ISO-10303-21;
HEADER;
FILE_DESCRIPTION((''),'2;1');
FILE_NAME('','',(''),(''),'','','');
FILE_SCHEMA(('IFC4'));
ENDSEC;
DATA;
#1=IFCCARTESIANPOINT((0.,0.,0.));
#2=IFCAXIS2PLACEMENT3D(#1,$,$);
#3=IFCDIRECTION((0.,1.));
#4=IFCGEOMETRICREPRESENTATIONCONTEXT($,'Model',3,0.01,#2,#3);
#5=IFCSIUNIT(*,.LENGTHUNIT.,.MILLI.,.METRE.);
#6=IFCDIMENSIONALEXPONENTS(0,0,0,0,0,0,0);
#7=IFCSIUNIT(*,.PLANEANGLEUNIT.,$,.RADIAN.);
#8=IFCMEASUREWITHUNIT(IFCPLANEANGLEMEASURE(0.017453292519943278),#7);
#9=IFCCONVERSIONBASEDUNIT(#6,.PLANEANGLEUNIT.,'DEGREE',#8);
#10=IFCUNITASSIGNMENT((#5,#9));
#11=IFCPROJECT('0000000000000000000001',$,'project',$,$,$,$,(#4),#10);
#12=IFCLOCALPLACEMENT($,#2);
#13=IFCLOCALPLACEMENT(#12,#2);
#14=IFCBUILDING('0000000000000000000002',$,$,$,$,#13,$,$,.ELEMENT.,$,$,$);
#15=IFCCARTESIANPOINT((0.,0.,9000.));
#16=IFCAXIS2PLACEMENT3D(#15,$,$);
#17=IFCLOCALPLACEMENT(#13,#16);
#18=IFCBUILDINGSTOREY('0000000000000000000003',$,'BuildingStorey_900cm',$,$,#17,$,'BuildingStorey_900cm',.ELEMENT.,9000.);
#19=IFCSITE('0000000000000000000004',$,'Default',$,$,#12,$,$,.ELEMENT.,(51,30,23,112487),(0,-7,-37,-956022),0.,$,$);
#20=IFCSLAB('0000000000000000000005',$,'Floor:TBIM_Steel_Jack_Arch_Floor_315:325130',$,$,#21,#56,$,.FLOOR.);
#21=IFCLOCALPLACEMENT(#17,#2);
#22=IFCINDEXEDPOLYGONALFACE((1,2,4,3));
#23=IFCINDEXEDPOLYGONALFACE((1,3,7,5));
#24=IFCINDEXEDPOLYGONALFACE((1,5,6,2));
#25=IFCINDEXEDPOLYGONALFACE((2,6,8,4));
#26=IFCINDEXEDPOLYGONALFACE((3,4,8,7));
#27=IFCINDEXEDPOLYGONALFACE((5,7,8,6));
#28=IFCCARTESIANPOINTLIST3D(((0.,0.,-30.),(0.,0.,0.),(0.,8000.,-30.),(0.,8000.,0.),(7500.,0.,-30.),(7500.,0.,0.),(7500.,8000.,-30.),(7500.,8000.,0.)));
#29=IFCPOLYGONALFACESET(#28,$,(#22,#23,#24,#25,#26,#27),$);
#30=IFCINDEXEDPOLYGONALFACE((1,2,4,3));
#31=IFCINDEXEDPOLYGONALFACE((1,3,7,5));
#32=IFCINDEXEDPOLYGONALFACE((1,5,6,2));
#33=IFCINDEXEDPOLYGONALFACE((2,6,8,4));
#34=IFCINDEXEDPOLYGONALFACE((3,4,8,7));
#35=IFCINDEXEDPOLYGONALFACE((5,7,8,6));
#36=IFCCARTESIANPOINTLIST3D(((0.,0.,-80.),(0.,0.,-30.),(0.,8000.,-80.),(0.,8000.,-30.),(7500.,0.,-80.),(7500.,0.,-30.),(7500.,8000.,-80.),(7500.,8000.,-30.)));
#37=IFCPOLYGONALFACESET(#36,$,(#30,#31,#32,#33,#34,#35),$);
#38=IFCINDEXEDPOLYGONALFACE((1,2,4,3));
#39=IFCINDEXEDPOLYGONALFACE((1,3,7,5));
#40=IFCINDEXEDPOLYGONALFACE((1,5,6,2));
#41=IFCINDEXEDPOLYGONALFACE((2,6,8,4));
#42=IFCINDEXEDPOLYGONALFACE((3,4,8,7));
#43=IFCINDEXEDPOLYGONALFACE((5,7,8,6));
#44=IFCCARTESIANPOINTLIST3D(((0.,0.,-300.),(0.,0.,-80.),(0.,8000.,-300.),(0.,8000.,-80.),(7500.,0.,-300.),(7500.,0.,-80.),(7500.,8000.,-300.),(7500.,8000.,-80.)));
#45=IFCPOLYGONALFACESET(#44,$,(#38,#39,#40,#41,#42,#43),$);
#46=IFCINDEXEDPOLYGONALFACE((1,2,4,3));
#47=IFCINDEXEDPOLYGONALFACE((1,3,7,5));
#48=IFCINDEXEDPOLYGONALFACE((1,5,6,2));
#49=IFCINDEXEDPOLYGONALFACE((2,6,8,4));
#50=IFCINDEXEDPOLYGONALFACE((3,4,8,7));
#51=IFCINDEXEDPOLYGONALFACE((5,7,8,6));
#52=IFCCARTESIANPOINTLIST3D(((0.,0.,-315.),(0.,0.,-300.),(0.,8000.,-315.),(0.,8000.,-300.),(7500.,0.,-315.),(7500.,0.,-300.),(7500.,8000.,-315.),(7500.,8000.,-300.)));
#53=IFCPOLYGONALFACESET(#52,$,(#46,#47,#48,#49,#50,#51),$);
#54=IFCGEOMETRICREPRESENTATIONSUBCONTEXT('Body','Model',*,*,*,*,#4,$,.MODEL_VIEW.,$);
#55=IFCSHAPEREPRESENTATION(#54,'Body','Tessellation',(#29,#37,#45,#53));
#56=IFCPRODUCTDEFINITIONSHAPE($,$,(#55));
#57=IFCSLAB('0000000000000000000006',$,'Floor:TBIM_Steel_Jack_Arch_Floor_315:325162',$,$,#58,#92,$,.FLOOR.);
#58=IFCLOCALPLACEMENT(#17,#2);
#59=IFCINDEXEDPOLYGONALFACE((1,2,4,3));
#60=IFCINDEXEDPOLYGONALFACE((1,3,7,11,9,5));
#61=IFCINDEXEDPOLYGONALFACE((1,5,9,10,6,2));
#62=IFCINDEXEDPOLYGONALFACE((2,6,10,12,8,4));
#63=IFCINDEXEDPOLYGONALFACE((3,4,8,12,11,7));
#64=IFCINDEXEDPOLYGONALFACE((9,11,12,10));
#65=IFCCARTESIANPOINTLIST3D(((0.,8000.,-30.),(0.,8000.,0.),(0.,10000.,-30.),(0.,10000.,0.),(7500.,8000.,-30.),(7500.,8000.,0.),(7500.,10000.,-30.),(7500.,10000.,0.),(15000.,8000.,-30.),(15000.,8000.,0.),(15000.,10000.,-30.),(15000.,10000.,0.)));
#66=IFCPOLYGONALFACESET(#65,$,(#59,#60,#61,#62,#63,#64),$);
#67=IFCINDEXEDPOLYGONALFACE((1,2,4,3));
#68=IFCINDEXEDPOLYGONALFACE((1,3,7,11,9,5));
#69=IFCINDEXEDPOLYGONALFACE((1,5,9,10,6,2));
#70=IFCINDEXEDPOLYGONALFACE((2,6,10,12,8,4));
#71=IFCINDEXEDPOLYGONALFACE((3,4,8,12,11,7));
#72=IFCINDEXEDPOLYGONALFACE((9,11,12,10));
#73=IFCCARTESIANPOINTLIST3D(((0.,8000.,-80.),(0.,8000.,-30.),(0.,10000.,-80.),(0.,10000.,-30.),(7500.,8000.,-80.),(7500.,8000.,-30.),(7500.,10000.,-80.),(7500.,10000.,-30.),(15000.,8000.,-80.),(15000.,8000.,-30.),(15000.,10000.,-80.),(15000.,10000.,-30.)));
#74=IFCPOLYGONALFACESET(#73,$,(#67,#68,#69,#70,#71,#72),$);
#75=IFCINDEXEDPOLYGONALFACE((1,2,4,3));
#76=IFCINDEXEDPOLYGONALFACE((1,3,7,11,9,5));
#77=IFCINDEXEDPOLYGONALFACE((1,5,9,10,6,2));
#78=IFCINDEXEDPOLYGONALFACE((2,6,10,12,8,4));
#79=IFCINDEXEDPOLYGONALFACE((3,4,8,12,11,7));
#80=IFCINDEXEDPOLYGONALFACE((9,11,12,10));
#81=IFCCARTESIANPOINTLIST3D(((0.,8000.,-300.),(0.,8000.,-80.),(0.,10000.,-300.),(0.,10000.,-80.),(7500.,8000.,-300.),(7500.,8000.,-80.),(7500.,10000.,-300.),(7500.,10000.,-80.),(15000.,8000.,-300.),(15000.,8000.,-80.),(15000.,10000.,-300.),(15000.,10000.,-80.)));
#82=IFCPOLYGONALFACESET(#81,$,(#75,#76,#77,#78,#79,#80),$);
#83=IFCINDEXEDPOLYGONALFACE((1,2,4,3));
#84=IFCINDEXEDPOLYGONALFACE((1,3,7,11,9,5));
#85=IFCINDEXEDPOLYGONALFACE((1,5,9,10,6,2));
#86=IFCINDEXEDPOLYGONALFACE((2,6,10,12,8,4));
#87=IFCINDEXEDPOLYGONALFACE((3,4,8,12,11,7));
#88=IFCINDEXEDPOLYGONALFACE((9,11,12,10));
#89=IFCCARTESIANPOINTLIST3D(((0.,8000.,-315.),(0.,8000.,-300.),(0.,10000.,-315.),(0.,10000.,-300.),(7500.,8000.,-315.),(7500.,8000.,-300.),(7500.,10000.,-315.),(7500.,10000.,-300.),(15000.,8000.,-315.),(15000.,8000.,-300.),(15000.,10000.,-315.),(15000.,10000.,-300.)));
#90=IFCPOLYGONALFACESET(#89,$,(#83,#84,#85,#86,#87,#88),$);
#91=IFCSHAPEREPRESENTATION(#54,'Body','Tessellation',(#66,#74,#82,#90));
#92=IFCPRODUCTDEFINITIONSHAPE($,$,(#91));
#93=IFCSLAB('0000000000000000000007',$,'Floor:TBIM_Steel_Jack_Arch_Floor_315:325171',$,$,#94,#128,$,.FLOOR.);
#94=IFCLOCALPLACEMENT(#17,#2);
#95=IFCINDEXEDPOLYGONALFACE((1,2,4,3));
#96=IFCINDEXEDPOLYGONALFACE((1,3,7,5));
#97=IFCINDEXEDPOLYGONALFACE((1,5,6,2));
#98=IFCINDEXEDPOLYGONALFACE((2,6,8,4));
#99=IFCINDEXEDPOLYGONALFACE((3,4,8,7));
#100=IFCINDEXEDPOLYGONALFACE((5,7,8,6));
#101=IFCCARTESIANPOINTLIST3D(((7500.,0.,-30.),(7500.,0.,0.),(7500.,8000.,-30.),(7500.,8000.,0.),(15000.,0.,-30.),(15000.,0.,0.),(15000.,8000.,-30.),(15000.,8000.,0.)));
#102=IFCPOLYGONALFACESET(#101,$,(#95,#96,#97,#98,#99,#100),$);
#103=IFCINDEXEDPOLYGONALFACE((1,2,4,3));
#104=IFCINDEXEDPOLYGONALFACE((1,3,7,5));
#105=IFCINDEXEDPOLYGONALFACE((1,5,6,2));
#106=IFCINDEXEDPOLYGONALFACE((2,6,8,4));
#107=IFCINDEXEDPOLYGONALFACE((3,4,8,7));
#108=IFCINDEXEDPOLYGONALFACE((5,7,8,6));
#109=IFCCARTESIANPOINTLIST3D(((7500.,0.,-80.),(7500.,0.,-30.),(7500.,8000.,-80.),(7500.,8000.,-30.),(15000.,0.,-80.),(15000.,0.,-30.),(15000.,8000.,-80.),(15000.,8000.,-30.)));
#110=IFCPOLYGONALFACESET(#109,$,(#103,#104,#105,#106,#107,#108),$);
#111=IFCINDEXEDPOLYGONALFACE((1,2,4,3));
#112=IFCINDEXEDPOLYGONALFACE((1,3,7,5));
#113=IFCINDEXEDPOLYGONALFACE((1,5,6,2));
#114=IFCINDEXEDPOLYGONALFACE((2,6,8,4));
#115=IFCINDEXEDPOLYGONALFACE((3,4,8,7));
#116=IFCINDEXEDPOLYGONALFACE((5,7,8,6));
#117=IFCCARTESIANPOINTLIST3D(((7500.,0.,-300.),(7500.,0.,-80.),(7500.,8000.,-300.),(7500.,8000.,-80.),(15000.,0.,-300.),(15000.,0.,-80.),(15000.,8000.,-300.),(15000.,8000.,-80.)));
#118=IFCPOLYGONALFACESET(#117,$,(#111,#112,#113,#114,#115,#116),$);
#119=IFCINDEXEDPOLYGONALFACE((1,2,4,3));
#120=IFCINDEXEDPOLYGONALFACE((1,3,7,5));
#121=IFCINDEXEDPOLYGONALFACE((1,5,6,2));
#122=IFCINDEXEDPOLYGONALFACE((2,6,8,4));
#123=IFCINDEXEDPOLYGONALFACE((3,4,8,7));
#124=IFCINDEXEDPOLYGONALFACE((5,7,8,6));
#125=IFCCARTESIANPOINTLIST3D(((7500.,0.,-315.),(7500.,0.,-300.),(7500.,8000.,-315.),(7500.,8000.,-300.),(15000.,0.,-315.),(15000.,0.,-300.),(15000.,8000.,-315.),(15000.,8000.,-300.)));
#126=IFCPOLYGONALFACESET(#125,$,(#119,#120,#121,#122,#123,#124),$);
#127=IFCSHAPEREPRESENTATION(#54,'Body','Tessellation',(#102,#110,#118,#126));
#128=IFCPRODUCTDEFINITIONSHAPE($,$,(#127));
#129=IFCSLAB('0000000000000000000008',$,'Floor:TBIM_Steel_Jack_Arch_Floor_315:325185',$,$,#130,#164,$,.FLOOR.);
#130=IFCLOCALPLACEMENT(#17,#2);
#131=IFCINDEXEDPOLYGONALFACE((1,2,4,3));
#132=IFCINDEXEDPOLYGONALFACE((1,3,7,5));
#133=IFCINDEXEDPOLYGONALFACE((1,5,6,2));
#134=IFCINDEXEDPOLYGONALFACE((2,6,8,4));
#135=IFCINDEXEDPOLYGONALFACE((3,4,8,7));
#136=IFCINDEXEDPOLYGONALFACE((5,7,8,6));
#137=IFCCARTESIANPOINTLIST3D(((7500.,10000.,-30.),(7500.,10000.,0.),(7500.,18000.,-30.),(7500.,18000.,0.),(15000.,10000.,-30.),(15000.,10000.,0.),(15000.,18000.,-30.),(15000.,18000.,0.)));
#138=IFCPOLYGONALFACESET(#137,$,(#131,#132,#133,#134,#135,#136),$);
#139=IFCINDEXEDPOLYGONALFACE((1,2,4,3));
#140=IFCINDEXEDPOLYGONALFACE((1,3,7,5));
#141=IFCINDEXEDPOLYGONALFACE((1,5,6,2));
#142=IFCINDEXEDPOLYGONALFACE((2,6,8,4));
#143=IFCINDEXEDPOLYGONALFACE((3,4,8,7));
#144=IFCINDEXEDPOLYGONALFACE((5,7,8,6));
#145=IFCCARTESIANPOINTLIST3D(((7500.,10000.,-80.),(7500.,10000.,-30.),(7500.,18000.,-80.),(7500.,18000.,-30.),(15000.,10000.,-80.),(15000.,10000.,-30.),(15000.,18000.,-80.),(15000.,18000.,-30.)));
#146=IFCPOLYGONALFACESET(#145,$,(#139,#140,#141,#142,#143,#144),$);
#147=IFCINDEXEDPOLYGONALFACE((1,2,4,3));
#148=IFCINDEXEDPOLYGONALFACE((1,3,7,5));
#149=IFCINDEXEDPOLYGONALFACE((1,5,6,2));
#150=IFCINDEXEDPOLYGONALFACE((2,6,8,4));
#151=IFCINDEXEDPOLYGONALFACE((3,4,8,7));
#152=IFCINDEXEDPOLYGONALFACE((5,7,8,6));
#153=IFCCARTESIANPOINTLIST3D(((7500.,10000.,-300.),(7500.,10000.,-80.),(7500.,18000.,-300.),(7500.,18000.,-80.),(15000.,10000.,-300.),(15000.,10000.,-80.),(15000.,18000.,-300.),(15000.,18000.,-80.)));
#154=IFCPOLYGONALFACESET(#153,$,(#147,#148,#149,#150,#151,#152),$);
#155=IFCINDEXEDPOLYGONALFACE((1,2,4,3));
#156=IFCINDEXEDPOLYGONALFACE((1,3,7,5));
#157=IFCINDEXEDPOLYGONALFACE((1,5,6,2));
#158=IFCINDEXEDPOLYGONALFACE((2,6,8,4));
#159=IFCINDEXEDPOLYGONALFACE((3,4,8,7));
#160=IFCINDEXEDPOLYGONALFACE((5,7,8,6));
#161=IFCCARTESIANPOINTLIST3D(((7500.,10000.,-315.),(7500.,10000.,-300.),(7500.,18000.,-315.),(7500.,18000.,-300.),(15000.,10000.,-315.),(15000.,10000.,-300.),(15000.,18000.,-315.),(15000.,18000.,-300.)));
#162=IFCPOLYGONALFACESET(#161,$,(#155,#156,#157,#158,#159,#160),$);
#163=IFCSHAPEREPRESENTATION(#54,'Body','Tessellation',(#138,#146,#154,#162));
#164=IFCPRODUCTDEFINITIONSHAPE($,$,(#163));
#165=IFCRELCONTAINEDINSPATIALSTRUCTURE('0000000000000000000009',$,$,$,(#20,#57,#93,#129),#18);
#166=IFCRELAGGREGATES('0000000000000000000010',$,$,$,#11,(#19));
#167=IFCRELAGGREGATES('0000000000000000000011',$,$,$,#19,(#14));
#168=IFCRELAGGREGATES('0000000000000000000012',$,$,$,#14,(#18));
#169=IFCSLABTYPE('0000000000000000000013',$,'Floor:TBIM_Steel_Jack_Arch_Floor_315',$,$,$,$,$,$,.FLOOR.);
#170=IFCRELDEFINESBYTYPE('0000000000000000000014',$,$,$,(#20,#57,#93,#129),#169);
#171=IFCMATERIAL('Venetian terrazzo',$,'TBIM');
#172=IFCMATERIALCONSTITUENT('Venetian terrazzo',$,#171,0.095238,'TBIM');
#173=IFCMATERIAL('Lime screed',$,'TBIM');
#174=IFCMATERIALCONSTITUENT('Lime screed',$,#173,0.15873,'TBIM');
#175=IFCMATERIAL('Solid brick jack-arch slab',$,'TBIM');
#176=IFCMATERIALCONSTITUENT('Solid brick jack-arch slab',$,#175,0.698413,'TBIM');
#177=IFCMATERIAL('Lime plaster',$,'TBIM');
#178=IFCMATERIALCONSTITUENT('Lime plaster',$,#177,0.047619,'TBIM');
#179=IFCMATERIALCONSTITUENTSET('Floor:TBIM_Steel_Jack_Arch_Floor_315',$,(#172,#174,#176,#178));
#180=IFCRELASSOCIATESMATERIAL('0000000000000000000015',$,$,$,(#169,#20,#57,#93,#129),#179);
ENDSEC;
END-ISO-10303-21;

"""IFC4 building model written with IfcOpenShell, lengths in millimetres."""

from ifc_helpers import new_model, entity, si_unit, converted_unit, direction, frame, origin, place, context, subcontext, project, spatial, indexed_curve, outline, extrude, material, constituent, constituent_set, type_object, element, save


model = new_model("IFC4")

# Units and contexts
model_context = context("Model", 3, precision=0.01, world=origin(), true_north=direction((0.0, 1.0)))
body_context = subcontext(model_context, "Body", "Model", "MODEL_VIEW")
ifc_project = project(units=[si_unit("LENGTHUNIT", "METRE", prefix="MILLI"), converted_unit("PLANEANGLEUNIT", "DEGREE", entity("IfcPlaneAngleMeasure", 0.017453292519943278), si_unit("PLANEANGLEUNIT", "RADIAN"), dimensions=[0, 0, 0, 0, 0, 0, 0])], contexts=[model_context])

# Site, building, storey
site_placement = place(None, origin())
site = spatial("IfcSite", under=ifc_project, at=site_placement, Name="Default", CompositionType="ELEMENT", RefLatitude=(51, 30, 23, 112487), RefLongitude=(0, -7, -37, -956022), RefElevation=0.0)
building_placement = place(site_placement, origin())
building = spatial("IfcBuilding", under=site, at=building_placement, CompositionType="ELEMENT")
storey_placement = place(building_placement, frame((0.0, 0.0, 9000.0)))
storey = spatial("IfcBuildingStorey", under=building, at=storey_placement, Name="BuildingStorey_900cm", LongName="BuildingStorey_900cm", CompositionType="ELEMENT", Elevation=9000.0)

# Slabs
ifc_material_1 = material(Name="Venetian terrazzo", Category="TBIM")
ifc_constituent_1 = constituent(ifc_material_1, Name="Venetian terrazzo", Category="TBIM", fraction=0.095238)
ifc_material_2 = material(Name="Lime screed", Category="TBIM")
ifc_constituent_2 = constituent(ifc_material_2, Name="Lime screed", Category="TBIM", fraction=0.15873)
ifc_material_3 = material(Name="Solid brick jack-arch slab", Category="TBIM")
ifc_constituent_3 = constituent(ifc_material_3, Name="Solid brick jack-arch slab", Category="TBIM", fraction=0.698413)
ifc_material_4 = material(Name="Lime plaster", Category="TBIM")
ifc_constituent_4 = constituent(ifc_material_4, Name="Lime plaster", Category="TBIM", fraction=0.047619)
ifc_constituent_set_1 = constituent_set(constituents=[ifc_constituent_1, ifc_constituent_2, ifc_constituent_3, ifc_constituent_4], Name="Floor:TBIM_Steel_Jack_Arch_Floor_315")
slab_type = type_object("IfcSlabType", Name="Floor:TBIM_Steel_Jack_Arch_Floor_315", PredefinedType="FLOOR", material=ifc_constituent_set_1)
slab_1_placement = place(storey_placement, origin())
element("IfcSlab", 1, at=slab_1_placement, inside=storey, type_object=slab_type, material=ifc_constituent_set_1, Name="Floor:TBIM_Steel_Jack_Arch_Floor_315:325130", PredefinedType="FLOOR", context=body_context, shape_type="SweptSolid", body=[
    extrude(outline(indexed_curve([(-3750.0, -4000.0), (3750.0, -4000.0), (3750.0, 4000.0), (-3750.0, 4000.0), (-3750.0, -4000.0)], self_intersect=False)), frame((3750.0, 4000.0, -30.0), z_axis=(0.0, 0.0, 1.0), x_axis=(-1.0, 0.0, 0.0)), (0.0, 0.0, 1.0), 30.0),
    extrude(outline(indexed_curve([(-3750.0, -4000.0), (3750.0, -4000.0), (3750.0, 4000.0), (-3750.0, 4000.0), (-3750.0, -4000.0)], self_intersect=False)), frame((3750.0, 4000.0, -80.0), z_axis=(0.0, 0.0, 1.0), x_axis=(-1.0, 0.0, 0.0)), (0.0, 0.0, 1.0), 50.0),
    extrude(outline(indexed_curve([(-3750.0, -4000.0), (3750.0, -4000.0), (3750.0, 4000.0), (-3750.0, 4000.0), (-3750.0, -4000.0)], self_intersect=False)), frame((3750.0, 4000.0, -300.0), z_axis=(0.0, 0.0, 1.0), x_axis=(-1.0, 0.0, 0.0)), (0.0, 0.0, 1.0), 220.0),
    extrude(outline(indexed_curve([(-3750.0, -4000.0), (3750.0, -4000.0), (3750.0, 4000.0), (-3750.0, 4000.0), (-3750.0, -4000.0)], self_intersect=False)), frame((3750.0, 4000.0, -315.0), z_axis=(0.0, 0.0, 1.0), x_axis=(-1.0, 0.0, 0.0)), (0.0, 0.0, 1.0), 15.0),
])
slab_2_placement = place(storey_placement, origin())
element("IfcSlab", 2, at=slab_2_placement, inside=storey, type_object=slab_type, material=ifc_constituent_set_1, Name="Floor:TBIM_Steel_Jack_Arch_Floor_315:325162", PredefinedType="FLOOR", context=body_context, shape_type="SweptSolid", body=[
    extrude(outline(indexed_curve([(-7500.0, -1000.0), (0.0, -1000.0), (7500.0, -1000.0), (7500.0, 1000.0), (0.0, 1000.0), (-7500.0, 1000.0), (-7500.0, -1000.0)], self_intersect=False)), frame((7500.0, 9000.0, -30.0), z_axis=(0.0, 0.0, 1.0), x_axis=(-1.0, 0.0, 0.0)), (0.0, 0.0, 1.0), 30.0),
    extrude(outline(indexed_curve([(-7500.0, -1000.0), (0.0, -1000.0), (7500.0, -1000.0), (7500.0, 1000.0), (0.0, 1000.0), (-7500.0, 1000.0), (-7500.0, -1000.0)], self_intersect=False)), frame((7500.0, 9000.0, -80.0), z_axis=(0.0, 0.0, 1.0), x_axis=(-1.0, 0.0, 0.0)), (0.0, 0.0, 1.0), 50.0),
    extrude(outline(indexed_curve([(-7500.0, -1000.0), (0.0, -1000.0), (7500.0, -1000.0), (7500.0, 1000.0), (0.0, 1000.0), (-7500.0, 1000.0), (-7500.0, -1000.0)], self_intersect=False)), frame((7500.0, 9000.0, -300.0), z_axis=(0.0, 0.0, 1.0), x_axis=(-1.0, 0.0, 0.0)), (0.0, 0.0, 1.0), 220.0),
    extrude(outline(indexed_curve([(-7500.0, -1000.0), (0.0, -1000.0), (7500.0, -1000.0), (7500.0, 1000.0), (0.0, 1000.0), (-7500.0, 1000.0), (-7500.0, -1000.0)], self_intersect=False)), frame((7500.0, 9000.0, -315.0), z_axis=(0.0, 0.0, 1.0), x_axis=(-1.0, 0.0, 0.0)), (0.0, 0.0, 1.0), 15.0),
])
slab_3_placement = place(storey_placement, origin())
element("IfcSlab", 3, at=slab_3_placement, inside=storey, type_object=slab_type, material=ifc_constituent_set_1, Name="Floor:TBIM_Steel_Jack_Arch_Floor_315:325171", PredefinedType="FLOOR", context=body_context, shape_type="SweptSolid", body=[
    extrude(outline(indexed_curve([(-3750.0, -4000.0), (3750.0, -4000.0), (3750.0, 4000.0), (-3750.0, 4000.0), (-3750.0, -4000.0)], self_intersect=False)), frame((11250.0, 4000.0, -30.0), z_axis=(0.0, 0.0, 1.0), x_axis=(-1.0, 0.0, 0.0)), (0.0, 0.0, 1.0), 30.0),
    extrude(outline(indexed_curve([(-3750.0, -4000.0), (3750.0, -4000.0), (3750.0, 4000.0), (-3750.0, 4000.0), (-3750.0, -4000.0)], self_intersect=False)), frame((11250.0, 4000.0, -80.0), z_axis=(0.0, 0.0, 1.0), x_axis=(-1.0, 0.0, 0.0)), (0.0, 0.0, 1.0), 50.0),
    extrude(outline(indexed_curve([(-3750.0, -4000.0), (3750.0, -4000.0), (3750.0, 4000.0), (-3750.0, 4000.0), (-3750.0, -4000.0)], self_intersect=False)), frame((11250.0, 4000.0, -300.0), z_axis=(0.0, 0.0, 1.0), x_axis=(-1.0, 0.0, 0.0)), (0.0, 0.0, 1.0), 220.0),
    extrude(outline(indexed_curve([(-3750.0, -4000.0), (3750.0, -4000.0), (3750.0, 4000.0), (-3750.0, 4000.0), (-3750.0, -4000.0)], self_intersect=False)), frame((11250.0, 4000.0, -315.0), z_axis=(0.0, 0.0, 1.0), x_axis=(-1.0, 0.0, 0.0)), (0.0, 0.0, 1.0), 15.0),
])
slab_4_placement = place(storey_placement, origin())
element("IfcSlab", 4, at=slab_4_placement, inside=storey, type_object=slab_type, material=ifc_constituent_set_1, Name="Floor:TBIM_Steel_Jack_Arch_Floor_315:325185", PredefinedType="FLOOR", context=body_context, shape_type="SweptSolid", body=[
    extrude(outline(indexed_curve([(-3750.0, -4000.0), (3750.0, -4000.0), (3750.0, 4000.0), (-3750.0, 4000.0), (-3750.0, -4000.0)], self_intersect=False)), frame((11250.0, 14000.0, -30.0), z_axis=(0.0, 0.0, 1.0), x_axis=(-1.0, 0.0, 0.0)), (0.0, 0.0, 1.0), 30.0),
    extrude(outline(indexed_curve([(-3750.0, -4000.0), (3750.0, -4000.0), (3750.0, 4000.0), (-3750.0, 4000.0), (-3750.0, -4000.0)], self_intersect=False)), frame((11250.0, 14000.0, -80.0), z_axis=(0.0, 0.0, 1.0), x_axis=(-1.0, 0.0, 0.0)), (0.0, 0.0, 1.0), 50.0),
    extrude(outline(indexed_curve([(-3750.0, -4000.0), (3750.0, -4000.0), (3750.0, 4000.0), (-3750.0, 4000.0), (-3750.0, -4000.0)], self_intersect=False)), frame((11250.0, 14000.0, -300.0), z_axis=(0.0, 0.0, 1.0), x_axis=(-1.0, 0.0, 0.0)), (0.0, 0.0, 1.0), 220.0),
    extrude(outline(indexed_curve([(-3750.0, -4000.0), (3750.0, -4000.0), (3750.0, 4000.0), (-3750.0, 4000.0), (-3750.0, -4000.0)], self_intersect=False)), frame((11250.0, 14000.0, -315.0), z_axis=(0.0, 0.0, 1.0), x_axis=(-1.0, 0.0, 0.0)), (0.0, 0.0, 1.0), 15.0),
])

save(model, "model.ifc")
